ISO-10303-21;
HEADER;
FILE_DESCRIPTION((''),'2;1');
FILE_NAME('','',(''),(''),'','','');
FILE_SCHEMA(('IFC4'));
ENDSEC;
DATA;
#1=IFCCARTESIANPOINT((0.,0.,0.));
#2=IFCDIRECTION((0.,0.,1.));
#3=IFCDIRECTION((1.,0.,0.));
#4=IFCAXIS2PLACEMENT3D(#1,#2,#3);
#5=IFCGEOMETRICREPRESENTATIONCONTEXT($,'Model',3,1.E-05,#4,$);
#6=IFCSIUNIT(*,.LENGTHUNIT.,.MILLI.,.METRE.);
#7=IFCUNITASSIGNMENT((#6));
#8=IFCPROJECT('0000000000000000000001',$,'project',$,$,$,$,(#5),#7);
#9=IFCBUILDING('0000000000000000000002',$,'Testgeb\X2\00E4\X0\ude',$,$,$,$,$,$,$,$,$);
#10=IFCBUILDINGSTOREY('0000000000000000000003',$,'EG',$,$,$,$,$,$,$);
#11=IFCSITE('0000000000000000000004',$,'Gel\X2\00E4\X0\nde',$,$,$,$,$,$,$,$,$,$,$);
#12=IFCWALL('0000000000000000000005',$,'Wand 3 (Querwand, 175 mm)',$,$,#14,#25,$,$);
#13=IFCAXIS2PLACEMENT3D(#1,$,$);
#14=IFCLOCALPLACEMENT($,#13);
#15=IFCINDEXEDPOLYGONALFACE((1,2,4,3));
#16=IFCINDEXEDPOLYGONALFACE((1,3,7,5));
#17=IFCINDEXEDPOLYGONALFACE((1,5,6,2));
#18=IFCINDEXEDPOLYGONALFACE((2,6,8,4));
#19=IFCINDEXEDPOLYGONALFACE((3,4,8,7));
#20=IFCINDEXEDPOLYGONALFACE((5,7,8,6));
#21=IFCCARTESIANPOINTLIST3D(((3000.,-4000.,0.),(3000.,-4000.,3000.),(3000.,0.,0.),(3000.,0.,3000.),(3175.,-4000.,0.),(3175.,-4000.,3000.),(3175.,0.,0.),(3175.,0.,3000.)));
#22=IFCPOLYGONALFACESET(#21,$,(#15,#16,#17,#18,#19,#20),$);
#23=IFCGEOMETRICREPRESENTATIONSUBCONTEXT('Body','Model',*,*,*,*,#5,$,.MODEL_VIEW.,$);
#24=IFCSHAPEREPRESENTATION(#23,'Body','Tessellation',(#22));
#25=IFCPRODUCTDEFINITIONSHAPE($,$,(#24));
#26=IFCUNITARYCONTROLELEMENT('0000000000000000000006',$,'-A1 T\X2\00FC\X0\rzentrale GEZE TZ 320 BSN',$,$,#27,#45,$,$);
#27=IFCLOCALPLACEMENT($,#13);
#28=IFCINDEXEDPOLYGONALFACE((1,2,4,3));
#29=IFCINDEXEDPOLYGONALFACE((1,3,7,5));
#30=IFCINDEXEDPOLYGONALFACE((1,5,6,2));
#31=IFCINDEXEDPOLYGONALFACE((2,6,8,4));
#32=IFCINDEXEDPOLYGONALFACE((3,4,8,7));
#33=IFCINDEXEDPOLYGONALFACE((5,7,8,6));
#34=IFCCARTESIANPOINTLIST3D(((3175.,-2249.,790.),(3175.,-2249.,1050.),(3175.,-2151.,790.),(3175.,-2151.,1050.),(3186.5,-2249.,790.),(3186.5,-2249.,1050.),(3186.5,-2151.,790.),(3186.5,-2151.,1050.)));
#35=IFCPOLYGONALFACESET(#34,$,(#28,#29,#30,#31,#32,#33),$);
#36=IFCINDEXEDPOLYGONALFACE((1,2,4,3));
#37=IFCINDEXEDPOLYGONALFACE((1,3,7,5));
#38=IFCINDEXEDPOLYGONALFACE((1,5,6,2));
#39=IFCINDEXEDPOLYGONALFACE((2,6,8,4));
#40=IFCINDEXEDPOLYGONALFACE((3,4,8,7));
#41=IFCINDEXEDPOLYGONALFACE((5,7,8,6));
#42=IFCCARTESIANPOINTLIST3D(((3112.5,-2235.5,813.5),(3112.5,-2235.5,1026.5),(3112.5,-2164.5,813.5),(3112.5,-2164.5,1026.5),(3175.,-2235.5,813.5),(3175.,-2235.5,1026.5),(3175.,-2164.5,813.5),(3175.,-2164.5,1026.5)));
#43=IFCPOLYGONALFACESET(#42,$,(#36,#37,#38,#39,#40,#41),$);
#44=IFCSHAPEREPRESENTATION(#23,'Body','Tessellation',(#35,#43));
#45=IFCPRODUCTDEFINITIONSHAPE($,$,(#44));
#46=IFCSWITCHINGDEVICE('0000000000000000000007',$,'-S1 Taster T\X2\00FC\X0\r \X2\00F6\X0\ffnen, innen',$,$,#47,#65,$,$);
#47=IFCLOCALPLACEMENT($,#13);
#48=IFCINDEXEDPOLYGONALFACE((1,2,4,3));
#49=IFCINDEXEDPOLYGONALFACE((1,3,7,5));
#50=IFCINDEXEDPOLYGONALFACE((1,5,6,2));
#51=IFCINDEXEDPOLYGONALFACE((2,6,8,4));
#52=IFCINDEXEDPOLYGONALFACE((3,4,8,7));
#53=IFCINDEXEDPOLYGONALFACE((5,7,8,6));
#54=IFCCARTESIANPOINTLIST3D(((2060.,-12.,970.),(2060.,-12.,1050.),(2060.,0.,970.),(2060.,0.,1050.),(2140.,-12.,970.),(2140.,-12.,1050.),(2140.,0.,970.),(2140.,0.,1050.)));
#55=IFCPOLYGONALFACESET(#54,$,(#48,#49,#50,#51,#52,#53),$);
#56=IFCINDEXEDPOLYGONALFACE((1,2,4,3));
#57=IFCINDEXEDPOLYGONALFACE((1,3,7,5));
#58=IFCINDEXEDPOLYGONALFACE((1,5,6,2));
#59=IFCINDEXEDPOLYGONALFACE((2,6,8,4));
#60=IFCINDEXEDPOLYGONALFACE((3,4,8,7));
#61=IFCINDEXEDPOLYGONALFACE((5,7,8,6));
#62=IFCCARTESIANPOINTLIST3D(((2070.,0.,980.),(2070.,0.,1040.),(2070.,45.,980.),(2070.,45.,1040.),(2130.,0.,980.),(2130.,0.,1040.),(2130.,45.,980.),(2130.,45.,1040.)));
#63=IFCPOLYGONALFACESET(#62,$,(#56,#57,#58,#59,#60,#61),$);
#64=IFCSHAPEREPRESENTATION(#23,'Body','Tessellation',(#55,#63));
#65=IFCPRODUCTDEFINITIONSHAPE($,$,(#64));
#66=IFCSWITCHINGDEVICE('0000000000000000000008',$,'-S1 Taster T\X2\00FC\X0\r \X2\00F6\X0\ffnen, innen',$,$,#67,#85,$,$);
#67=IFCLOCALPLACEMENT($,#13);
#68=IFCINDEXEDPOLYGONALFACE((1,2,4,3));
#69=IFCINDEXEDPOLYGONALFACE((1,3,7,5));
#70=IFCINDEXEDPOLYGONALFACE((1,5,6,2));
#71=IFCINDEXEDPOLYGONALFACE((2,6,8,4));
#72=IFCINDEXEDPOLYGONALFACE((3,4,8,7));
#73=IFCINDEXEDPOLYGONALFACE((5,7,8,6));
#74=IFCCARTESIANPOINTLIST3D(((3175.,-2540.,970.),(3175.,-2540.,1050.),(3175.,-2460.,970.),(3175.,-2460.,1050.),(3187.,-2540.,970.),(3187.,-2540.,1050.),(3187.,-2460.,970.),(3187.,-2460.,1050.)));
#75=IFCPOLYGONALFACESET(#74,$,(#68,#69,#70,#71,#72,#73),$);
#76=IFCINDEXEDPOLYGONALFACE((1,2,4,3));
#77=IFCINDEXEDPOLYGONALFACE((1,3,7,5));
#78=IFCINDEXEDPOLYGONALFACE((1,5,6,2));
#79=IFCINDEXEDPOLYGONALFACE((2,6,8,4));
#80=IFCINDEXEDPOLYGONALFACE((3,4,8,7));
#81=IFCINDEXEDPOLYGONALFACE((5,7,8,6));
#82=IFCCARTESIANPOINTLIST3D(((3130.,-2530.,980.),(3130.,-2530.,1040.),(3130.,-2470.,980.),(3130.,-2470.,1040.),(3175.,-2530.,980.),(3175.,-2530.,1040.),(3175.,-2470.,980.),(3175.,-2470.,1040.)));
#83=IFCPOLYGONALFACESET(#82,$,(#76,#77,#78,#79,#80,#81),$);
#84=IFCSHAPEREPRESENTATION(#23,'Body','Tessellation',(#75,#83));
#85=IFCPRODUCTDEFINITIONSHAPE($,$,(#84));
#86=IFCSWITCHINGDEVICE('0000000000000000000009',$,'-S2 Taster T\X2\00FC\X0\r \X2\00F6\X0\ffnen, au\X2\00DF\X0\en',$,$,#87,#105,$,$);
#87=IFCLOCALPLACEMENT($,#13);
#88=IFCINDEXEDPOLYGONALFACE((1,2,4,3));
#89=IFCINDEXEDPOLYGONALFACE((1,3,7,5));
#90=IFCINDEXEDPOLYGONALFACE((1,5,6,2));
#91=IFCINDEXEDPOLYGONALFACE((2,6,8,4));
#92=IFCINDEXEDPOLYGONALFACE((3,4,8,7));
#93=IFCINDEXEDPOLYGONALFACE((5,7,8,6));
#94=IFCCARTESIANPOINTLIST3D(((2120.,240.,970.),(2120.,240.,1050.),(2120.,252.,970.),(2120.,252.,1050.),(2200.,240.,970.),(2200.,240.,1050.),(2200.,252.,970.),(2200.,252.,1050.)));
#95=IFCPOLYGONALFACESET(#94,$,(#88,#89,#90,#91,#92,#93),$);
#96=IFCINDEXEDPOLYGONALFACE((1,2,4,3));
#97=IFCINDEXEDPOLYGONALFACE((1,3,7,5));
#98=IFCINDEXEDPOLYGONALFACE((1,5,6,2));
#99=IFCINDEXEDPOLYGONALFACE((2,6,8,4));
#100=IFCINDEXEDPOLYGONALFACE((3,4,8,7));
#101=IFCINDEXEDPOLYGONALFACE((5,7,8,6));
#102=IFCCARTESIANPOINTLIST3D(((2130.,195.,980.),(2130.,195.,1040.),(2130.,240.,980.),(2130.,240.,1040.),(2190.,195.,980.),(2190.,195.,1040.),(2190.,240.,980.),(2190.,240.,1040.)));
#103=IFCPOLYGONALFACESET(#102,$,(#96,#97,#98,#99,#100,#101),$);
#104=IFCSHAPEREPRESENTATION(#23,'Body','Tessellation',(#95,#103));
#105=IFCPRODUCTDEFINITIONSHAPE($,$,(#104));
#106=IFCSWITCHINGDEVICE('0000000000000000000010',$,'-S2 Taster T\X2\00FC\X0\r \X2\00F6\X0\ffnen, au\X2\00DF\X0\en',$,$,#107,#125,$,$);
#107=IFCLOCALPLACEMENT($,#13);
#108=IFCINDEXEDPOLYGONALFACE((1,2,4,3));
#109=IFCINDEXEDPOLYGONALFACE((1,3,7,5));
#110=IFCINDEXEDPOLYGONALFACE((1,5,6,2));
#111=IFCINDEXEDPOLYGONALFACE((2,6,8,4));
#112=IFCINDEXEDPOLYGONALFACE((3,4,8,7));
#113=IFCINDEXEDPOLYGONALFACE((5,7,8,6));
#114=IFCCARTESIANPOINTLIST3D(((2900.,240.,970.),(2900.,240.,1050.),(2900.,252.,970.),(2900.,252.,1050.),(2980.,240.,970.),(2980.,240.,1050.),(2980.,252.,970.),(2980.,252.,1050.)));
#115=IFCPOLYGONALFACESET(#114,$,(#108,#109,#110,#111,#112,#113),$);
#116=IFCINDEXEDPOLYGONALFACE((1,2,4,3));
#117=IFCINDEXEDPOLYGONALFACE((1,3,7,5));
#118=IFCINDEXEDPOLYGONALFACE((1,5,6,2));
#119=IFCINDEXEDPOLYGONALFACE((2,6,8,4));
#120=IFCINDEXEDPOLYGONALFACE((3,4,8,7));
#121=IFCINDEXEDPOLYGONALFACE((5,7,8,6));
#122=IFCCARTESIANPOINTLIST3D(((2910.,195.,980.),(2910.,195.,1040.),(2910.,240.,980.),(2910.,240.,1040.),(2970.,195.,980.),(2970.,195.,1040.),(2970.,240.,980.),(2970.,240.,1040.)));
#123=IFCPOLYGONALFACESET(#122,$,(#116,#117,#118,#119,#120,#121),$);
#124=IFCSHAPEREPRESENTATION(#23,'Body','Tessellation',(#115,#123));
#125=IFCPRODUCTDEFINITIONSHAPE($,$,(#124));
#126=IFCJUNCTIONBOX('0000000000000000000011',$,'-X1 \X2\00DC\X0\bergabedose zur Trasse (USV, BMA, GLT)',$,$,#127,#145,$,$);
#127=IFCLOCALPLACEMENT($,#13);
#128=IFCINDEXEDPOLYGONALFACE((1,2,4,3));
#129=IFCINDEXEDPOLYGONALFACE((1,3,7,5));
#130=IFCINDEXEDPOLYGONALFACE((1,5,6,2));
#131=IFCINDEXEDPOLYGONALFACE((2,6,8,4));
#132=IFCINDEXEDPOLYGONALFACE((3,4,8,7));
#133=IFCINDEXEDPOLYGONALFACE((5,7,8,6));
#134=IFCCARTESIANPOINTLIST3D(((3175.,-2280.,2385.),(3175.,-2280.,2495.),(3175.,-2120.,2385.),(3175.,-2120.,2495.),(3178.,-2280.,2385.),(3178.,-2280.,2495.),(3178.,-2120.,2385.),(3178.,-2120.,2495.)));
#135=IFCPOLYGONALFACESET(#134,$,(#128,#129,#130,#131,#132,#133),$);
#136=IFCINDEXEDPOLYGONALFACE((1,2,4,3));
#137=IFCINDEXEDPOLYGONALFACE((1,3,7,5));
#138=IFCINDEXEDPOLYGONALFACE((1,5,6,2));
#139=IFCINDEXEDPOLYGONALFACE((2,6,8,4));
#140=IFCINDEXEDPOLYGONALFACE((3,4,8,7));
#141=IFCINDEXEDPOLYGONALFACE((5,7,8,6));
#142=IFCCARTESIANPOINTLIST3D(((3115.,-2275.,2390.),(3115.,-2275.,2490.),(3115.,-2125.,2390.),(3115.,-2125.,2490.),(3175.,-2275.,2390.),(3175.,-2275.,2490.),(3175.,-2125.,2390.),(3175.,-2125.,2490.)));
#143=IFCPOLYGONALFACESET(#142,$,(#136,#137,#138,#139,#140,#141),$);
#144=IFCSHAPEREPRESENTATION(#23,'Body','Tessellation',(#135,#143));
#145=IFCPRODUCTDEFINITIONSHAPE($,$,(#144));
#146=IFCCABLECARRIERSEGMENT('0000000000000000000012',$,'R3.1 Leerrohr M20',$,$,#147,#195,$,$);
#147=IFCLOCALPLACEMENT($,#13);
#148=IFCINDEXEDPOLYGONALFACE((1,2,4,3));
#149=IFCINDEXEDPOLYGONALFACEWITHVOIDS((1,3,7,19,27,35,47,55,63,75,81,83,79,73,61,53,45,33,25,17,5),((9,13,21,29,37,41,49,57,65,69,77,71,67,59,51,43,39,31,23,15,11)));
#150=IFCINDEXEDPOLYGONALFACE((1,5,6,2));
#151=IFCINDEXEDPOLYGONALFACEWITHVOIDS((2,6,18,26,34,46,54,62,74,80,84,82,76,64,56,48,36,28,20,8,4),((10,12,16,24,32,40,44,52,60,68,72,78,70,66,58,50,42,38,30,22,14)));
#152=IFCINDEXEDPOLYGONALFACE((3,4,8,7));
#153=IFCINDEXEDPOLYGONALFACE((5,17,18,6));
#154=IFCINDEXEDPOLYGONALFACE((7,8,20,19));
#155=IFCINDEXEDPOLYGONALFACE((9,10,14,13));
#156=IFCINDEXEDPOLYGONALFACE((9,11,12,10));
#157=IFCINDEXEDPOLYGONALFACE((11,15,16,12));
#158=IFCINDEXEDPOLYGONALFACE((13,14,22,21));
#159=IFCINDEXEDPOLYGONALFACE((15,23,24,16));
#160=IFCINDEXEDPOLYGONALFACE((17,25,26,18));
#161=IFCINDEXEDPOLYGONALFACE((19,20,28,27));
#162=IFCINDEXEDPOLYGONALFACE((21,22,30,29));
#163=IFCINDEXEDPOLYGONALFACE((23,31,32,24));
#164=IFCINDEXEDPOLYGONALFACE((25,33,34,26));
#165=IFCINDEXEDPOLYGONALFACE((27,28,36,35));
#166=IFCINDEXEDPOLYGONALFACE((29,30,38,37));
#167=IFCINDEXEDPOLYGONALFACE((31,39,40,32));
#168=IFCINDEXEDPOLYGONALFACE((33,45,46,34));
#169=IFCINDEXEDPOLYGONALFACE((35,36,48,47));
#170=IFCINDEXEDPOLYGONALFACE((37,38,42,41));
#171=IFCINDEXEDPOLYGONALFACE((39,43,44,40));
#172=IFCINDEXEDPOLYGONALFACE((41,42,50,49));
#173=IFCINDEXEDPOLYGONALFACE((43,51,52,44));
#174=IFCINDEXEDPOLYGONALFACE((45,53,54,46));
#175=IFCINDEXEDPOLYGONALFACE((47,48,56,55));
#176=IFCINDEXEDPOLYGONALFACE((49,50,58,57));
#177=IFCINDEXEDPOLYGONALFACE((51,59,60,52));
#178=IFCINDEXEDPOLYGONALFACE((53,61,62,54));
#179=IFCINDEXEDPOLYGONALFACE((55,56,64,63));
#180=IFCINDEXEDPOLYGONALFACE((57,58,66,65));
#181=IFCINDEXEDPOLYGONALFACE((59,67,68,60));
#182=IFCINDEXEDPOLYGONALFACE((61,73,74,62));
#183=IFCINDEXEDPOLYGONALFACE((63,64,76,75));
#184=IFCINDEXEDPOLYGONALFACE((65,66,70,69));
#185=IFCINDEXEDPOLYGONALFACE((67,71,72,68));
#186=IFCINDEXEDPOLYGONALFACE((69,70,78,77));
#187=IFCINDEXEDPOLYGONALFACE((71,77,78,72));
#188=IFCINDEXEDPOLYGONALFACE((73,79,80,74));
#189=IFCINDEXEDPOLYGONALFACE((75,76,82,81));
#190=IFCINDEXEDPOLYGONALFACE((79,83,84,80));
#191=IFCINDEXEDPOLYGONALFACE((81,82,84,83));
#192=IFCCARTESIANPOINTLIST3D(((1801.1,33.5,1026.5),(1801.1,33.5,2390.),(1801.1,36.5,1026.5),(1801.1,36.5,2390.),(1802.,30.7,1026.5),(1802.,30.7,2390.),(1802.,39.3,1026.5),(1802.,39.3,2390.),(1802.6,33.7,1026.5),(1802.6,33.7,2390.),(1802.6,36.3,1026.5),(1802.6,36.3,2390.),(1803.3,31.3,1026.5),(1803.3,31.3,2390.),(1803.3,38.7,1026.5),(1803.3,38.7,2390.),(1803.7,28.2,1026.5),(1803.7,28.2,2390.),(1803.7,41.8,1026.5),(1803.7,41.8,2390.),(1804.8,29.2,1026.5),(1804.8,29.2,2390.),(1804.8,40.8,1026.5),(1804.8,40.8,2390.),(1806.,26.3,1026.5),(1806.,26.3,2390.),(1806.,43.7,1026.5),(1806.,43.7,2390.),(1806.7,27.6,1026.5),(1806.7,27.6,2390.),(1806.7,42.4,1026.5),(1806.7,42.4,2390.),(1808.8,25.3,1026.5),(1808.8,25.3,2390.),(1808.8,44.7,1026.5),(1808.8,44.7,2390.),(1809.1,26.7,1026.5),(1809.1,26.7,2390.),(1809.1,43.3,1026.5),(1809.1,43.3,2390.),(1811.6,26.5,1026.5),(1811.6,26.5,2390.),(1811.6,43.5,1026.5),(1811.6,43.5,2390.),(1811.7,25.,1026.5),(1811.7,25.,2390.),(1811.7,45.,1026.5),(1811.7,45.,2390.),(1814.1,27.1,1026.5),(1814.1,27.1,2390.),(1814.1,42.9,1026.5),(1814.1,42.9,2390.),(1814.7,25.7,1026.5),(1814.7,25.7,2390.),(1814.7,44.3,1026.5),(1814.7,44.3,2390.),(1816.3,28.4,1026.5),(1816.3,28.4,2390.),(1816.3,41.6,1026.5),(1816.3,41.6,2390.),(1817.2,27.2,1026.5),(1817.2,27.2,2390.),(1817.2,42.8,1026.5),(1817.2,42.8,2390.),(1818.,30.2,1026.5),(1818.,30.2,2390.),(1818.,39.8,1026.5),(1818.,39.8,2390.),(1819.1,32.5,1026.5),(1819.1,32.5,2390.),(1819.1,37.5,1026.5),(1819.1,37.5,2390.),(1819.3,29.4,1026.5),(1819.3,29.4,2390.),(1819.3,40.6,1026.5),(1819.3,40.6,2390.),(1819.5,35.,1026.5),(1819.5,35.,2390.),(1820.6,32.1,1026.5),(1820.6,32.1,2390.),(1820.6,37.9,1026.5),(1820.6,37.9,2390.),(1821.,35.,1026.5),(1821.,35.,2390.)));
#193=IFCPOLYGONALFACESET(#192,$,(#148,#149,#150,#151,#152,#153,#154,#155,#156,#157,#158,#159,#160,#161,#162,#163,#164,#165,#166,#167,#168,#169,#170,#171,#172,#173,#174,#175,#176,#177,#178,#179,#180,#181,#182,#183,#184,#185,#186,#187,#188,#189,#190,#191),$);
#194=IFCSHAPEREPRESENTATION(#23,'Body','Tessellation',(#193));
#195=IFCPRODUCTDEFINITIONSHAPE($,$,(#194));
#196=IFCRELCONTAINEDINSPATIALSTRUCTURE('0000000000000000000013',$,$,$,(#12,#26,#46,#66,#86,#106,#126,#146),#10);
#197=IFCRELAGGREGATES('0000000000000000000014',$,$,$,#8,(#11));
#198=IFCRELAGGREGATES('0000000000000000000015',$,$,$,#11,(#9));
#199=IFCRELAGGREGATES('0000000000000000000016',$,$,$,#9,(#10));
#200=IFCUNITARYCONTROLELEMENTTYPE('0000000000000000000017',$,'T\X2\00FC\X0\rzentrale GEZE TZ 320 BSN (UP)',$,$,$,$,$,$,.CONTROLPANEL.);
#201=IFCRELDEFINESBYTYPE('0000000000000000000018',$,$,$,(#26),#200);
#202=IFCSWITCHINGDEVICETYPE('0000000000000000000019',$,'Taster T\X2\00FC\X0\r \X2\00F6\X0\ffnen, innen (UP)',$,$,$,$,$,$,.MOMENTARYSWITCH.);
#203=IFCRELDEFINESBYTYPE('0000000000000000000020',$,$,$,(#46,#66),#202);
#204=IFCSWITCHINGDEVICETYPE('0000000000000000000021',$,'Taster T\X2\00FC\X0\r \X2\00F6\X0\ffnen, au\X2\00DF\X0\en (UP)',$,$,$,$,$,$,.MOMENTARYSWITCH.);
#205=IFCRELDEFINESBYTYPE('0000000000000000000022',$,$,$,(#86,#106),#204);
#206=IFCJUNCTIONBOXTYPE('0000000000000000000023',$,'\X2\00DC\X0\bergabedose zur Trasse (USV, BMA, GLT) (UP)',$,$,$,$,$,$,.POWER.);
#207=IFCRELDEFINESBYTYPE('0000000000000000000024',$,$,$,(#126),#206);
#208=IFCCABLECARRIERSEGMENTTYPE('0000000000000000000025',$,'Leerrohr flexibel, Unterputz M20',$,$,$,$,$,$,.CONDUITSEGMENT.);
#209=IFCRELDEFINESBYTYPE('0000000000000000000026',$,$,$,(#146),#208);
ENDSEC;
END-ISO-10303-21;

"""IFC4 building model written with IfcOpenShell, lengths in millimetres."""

from ifc_helpers import new_model, si_unit, frame, frame_2d, origin_with_axes, place, context, subcontext, project, spatial, rectangle, hollow_circle, extrude, type_object, element, save


model = new_model("IFC4")

# Units and contexts
model_context = context("Model", 3, precision=1e-05, world=origin_with_axes())
body_context = subcontext(model_context, "Body", "Model", "MODEL_VIEW")
ifc_project = project(units=[si_unit("LENGTHUNIT", "METRE", prefix="MILLI")], contexts=[model_context])

# Site, building, storey
site = spatial("IfcSite", under=ifc_project, Name="Gelände")
building = spatial("IfcBuilding", under=site, Name="Testgebäude")
storey = spatial("IfcBuildingStorey", under=building, Name="EG")

# Wall
wall_placement = place(None, frame((3000.0, 0.0, 0.0), z_axis=(0.0, 0.0, 1.0), x_axis=(0.0, -1.0, 0.0)))
element("IfcWall", 1, at=wall_placement, inside=storey, Name="Wand 3 (Querwand, 175 mm)", context=body_context, shape_type="SweptSolid", body=[
    extrude(rectangle(XDim=4000.0, YDim=175.0, at=frame_2d((2000.0, 87.5))), None, (0.0, 0.0, 1.0), 3000.0),
])

# Unitary control element
unitary_control_element_type = type_object("IfcUnitaryControlElementType", Name="Türzentrale GEZE TZ 320 BSN (UP)", PredefinedType="CONTROLPANEL")
unitary_control_element_placement = place(None, frame((3175.0, -2249.0, 790.0), z_axis=(0.0, 0.0, 1.0), x_axis=(1.0, 0.0, 0.0)))
element("IfcUnitaryControlElement", 2, at=unitary_control_element_placement, inside=storey, type_object=unitary_control_element_type, Name="-A1 Türzentrale GEZE TZ 320 BSN", context=body_context, shape_type="SweptSolid", body=[
    extrude(rectangle(XDim=11.5, YDim=98.0, at=frame_2d((5.8, 49.0))), None, (0.0, 0.0, 1.0), 260.0),
    extrude(rectangle(XDim=62.5, YDim=71.0, at=frame_2d((31.2, 35.5))), frame((-62.5, 13.5, 23.5), z_axis=(0.0, 0.0, 1.0), x_axis=(1.0, 0.0, 0.0)), (0.0, 0.0, 1.0), 213.0),
])

# Switching devices
switching_device_type_1 = type_object("IfcSwitchingDeviceType", Name="Taster Tür öffnen, innen (UP)", PredefinedType="MOMENTARYSWITCH")
switching_device_1_placement = place(None, frame((2060.0, -12.0, 970.0), z_axis=(0.0, 0.0, 1.0), x_axis=(1.0, 0.0, 0.0)))
element("IfcSwitchingDevice", 3, at=switching_device_1_placement, inside=storey, type_object=switching_device_type_1, Name="-S1 Taster Tür öffnen, innen", context=body_context, shape_type="SweptSolid", body=[
    extrude(rectangle(XDim=80.0, YDim=12.0, at=frame_2d((40.0, 6.0))), None, (0.0, 0.0, 1.0), 80.0),
    extrude(rectangle(XDim=60.0, YDim=45.0, at=frame_2d((30.0, 22.5))), frame((10.0, 12.0, 10.0), z_axis=(0.0, 0.0, 1.0), x_axis=(1.0, 0.0, 0.0)), (0.0, 0.0, 1.0), 60.0),
])
switching_device_2_placement = place(None, frame((3175.0, -2540.0, 970.0), z_axis=(0.0, 0.0, 1.0), x_axis=(1.0, 0.0, 0.0)))
element("IfcSwitchingDevice", 4, at=switching_device_2_placement, inside=storey, type_object=switching_device_type_1, Name="-S1 Taster Tür öffnen, innen", context=body_context, shape_type="SweptSolid", body=[
    extrude(rectangle(XDim=12.0, YDim=80.0, at=frame_2d((6.0, 40.0))), None, (0.0, 0.0, 1.0), 80.0),
    extrude(rectangle(XDim=45.0, YDim=60.0, at=frame_2d((22.5, 30.0))), frame((-45.0, 10.0, 10.0), z_axis=(0.0, 0.0, 1.0), x_axis=(1.0, 0.0, 0.0)), (0.0, 0.0, 1.0), 60.0),
])
switching_device_type_2 = type_object("IfcSwitchingDeviceType", Name="Taster Tür öffnen, außen (UP)", PredefinedType="MOMENTARYSWITCH")
for number, where, z_axis, x_axis, name in (
    (5, (2120.0, 240.0, 970.0), (0.0, 0.0, 1.0), (1.0, 0.0, 0.0), "-S2 Taster Tür öffnen, außen"),
    (6, (2900.0, 240.0, 970.0), (0.0, 0.0, 1.0), (1.0, 0.0, 0.0), "-S2 Taster Tür öffnen, außen"),
):
    element("IfcSwitchingDevice", number, at=place(None, frame(where, z_axis=z_axis, x_axis=x_axis)), inside=storey, type_object=switching_device_type_2, Name=name, context=body_context, shape_type="SweptSolid", body=[
        extrude(rectangle(XDim=80.0, YDim=12.0, at=frame_2d((40.0, 6.0))), None, (0.0, 0.0, 1.0), 80.0),
        extrude(rectangle(XDim=60.0, YDim=45.0, at=frame_2d((30.0, 22.5))), frame((10.0, -45.0, 10.0), z_axis=(0.0, 0.0, 1.0), x_axis=(1.0, 0.0, 0.0)), (0.0, 0.0, 1.0), 60.0),
    ])

# Junction box
junction_box_type = type_object("IfcJunctionBoxType", Name="Übergabedose zur Trasse (USV, BMA, GLT) (UP)", PredefinedType="POWER")
junction_box_placement = place(None, frame((3175.0, -2280.0, 2385.0), z_axis=(0.0, 0.0, 1.0), x_axis=(1.0, 0.0, 0.0)))
element("IfcJunctionBox", 7, at=junction_box_placement, inside=storey, type_object=junction_box_type, Name="-X1 Übergabedose zur Trasse (USV, BMA, GLT)", context=body_context, shape_type="SweptSolid", body=[
    extrude(rectangle(XDim=3.0, YDim=160.0, at=frame_2d((1.5, 80.0))), None, (0.0, 0.0, 1.0), 110.0),
    extrude(rectangle(XDim=60.0, YDim=150.0, at=frame_2d((30.0, 75.0))), frame((-60.0, 5.0, 5.0), z_axis=(0.0, 0.0, 1.0), x_axis=(1.0, 0.0, 0.0)), (0.0, 0.0, 1.0), 100.0),
])

# Cable carrier segment
cable_carrier_segment_type_1 = type_object("IfcCableCarrierSegmentType", Name="Leerrohr flexibel, Unterputz M20", PredefinedType="CONDUITSEGMENT")
for number, where, z_axis, x_axis, name in (
    (8, (1811.0, 35.0, 1026.5), (0.0, 0.0, 1.0), (1.0, 0.0, 0.0), "R3.1 Leerrohr M20"),
):
    element("IfcCableCarrierSegment", number, at=place(None, frame(where, z_axis=z_axis, x_axis=x_axis)), inside=storey, type_object=cable_carrier_segment_type_1, Name=name, context=body_context, shape_type="SweptSolid", body=[
        extrude(hollow_circle(Radius=10.0, WallThickness=1.5), None, (0.0, 0.0, 1.0), 1363.5),
    ])

save(model, "model.ifc")
